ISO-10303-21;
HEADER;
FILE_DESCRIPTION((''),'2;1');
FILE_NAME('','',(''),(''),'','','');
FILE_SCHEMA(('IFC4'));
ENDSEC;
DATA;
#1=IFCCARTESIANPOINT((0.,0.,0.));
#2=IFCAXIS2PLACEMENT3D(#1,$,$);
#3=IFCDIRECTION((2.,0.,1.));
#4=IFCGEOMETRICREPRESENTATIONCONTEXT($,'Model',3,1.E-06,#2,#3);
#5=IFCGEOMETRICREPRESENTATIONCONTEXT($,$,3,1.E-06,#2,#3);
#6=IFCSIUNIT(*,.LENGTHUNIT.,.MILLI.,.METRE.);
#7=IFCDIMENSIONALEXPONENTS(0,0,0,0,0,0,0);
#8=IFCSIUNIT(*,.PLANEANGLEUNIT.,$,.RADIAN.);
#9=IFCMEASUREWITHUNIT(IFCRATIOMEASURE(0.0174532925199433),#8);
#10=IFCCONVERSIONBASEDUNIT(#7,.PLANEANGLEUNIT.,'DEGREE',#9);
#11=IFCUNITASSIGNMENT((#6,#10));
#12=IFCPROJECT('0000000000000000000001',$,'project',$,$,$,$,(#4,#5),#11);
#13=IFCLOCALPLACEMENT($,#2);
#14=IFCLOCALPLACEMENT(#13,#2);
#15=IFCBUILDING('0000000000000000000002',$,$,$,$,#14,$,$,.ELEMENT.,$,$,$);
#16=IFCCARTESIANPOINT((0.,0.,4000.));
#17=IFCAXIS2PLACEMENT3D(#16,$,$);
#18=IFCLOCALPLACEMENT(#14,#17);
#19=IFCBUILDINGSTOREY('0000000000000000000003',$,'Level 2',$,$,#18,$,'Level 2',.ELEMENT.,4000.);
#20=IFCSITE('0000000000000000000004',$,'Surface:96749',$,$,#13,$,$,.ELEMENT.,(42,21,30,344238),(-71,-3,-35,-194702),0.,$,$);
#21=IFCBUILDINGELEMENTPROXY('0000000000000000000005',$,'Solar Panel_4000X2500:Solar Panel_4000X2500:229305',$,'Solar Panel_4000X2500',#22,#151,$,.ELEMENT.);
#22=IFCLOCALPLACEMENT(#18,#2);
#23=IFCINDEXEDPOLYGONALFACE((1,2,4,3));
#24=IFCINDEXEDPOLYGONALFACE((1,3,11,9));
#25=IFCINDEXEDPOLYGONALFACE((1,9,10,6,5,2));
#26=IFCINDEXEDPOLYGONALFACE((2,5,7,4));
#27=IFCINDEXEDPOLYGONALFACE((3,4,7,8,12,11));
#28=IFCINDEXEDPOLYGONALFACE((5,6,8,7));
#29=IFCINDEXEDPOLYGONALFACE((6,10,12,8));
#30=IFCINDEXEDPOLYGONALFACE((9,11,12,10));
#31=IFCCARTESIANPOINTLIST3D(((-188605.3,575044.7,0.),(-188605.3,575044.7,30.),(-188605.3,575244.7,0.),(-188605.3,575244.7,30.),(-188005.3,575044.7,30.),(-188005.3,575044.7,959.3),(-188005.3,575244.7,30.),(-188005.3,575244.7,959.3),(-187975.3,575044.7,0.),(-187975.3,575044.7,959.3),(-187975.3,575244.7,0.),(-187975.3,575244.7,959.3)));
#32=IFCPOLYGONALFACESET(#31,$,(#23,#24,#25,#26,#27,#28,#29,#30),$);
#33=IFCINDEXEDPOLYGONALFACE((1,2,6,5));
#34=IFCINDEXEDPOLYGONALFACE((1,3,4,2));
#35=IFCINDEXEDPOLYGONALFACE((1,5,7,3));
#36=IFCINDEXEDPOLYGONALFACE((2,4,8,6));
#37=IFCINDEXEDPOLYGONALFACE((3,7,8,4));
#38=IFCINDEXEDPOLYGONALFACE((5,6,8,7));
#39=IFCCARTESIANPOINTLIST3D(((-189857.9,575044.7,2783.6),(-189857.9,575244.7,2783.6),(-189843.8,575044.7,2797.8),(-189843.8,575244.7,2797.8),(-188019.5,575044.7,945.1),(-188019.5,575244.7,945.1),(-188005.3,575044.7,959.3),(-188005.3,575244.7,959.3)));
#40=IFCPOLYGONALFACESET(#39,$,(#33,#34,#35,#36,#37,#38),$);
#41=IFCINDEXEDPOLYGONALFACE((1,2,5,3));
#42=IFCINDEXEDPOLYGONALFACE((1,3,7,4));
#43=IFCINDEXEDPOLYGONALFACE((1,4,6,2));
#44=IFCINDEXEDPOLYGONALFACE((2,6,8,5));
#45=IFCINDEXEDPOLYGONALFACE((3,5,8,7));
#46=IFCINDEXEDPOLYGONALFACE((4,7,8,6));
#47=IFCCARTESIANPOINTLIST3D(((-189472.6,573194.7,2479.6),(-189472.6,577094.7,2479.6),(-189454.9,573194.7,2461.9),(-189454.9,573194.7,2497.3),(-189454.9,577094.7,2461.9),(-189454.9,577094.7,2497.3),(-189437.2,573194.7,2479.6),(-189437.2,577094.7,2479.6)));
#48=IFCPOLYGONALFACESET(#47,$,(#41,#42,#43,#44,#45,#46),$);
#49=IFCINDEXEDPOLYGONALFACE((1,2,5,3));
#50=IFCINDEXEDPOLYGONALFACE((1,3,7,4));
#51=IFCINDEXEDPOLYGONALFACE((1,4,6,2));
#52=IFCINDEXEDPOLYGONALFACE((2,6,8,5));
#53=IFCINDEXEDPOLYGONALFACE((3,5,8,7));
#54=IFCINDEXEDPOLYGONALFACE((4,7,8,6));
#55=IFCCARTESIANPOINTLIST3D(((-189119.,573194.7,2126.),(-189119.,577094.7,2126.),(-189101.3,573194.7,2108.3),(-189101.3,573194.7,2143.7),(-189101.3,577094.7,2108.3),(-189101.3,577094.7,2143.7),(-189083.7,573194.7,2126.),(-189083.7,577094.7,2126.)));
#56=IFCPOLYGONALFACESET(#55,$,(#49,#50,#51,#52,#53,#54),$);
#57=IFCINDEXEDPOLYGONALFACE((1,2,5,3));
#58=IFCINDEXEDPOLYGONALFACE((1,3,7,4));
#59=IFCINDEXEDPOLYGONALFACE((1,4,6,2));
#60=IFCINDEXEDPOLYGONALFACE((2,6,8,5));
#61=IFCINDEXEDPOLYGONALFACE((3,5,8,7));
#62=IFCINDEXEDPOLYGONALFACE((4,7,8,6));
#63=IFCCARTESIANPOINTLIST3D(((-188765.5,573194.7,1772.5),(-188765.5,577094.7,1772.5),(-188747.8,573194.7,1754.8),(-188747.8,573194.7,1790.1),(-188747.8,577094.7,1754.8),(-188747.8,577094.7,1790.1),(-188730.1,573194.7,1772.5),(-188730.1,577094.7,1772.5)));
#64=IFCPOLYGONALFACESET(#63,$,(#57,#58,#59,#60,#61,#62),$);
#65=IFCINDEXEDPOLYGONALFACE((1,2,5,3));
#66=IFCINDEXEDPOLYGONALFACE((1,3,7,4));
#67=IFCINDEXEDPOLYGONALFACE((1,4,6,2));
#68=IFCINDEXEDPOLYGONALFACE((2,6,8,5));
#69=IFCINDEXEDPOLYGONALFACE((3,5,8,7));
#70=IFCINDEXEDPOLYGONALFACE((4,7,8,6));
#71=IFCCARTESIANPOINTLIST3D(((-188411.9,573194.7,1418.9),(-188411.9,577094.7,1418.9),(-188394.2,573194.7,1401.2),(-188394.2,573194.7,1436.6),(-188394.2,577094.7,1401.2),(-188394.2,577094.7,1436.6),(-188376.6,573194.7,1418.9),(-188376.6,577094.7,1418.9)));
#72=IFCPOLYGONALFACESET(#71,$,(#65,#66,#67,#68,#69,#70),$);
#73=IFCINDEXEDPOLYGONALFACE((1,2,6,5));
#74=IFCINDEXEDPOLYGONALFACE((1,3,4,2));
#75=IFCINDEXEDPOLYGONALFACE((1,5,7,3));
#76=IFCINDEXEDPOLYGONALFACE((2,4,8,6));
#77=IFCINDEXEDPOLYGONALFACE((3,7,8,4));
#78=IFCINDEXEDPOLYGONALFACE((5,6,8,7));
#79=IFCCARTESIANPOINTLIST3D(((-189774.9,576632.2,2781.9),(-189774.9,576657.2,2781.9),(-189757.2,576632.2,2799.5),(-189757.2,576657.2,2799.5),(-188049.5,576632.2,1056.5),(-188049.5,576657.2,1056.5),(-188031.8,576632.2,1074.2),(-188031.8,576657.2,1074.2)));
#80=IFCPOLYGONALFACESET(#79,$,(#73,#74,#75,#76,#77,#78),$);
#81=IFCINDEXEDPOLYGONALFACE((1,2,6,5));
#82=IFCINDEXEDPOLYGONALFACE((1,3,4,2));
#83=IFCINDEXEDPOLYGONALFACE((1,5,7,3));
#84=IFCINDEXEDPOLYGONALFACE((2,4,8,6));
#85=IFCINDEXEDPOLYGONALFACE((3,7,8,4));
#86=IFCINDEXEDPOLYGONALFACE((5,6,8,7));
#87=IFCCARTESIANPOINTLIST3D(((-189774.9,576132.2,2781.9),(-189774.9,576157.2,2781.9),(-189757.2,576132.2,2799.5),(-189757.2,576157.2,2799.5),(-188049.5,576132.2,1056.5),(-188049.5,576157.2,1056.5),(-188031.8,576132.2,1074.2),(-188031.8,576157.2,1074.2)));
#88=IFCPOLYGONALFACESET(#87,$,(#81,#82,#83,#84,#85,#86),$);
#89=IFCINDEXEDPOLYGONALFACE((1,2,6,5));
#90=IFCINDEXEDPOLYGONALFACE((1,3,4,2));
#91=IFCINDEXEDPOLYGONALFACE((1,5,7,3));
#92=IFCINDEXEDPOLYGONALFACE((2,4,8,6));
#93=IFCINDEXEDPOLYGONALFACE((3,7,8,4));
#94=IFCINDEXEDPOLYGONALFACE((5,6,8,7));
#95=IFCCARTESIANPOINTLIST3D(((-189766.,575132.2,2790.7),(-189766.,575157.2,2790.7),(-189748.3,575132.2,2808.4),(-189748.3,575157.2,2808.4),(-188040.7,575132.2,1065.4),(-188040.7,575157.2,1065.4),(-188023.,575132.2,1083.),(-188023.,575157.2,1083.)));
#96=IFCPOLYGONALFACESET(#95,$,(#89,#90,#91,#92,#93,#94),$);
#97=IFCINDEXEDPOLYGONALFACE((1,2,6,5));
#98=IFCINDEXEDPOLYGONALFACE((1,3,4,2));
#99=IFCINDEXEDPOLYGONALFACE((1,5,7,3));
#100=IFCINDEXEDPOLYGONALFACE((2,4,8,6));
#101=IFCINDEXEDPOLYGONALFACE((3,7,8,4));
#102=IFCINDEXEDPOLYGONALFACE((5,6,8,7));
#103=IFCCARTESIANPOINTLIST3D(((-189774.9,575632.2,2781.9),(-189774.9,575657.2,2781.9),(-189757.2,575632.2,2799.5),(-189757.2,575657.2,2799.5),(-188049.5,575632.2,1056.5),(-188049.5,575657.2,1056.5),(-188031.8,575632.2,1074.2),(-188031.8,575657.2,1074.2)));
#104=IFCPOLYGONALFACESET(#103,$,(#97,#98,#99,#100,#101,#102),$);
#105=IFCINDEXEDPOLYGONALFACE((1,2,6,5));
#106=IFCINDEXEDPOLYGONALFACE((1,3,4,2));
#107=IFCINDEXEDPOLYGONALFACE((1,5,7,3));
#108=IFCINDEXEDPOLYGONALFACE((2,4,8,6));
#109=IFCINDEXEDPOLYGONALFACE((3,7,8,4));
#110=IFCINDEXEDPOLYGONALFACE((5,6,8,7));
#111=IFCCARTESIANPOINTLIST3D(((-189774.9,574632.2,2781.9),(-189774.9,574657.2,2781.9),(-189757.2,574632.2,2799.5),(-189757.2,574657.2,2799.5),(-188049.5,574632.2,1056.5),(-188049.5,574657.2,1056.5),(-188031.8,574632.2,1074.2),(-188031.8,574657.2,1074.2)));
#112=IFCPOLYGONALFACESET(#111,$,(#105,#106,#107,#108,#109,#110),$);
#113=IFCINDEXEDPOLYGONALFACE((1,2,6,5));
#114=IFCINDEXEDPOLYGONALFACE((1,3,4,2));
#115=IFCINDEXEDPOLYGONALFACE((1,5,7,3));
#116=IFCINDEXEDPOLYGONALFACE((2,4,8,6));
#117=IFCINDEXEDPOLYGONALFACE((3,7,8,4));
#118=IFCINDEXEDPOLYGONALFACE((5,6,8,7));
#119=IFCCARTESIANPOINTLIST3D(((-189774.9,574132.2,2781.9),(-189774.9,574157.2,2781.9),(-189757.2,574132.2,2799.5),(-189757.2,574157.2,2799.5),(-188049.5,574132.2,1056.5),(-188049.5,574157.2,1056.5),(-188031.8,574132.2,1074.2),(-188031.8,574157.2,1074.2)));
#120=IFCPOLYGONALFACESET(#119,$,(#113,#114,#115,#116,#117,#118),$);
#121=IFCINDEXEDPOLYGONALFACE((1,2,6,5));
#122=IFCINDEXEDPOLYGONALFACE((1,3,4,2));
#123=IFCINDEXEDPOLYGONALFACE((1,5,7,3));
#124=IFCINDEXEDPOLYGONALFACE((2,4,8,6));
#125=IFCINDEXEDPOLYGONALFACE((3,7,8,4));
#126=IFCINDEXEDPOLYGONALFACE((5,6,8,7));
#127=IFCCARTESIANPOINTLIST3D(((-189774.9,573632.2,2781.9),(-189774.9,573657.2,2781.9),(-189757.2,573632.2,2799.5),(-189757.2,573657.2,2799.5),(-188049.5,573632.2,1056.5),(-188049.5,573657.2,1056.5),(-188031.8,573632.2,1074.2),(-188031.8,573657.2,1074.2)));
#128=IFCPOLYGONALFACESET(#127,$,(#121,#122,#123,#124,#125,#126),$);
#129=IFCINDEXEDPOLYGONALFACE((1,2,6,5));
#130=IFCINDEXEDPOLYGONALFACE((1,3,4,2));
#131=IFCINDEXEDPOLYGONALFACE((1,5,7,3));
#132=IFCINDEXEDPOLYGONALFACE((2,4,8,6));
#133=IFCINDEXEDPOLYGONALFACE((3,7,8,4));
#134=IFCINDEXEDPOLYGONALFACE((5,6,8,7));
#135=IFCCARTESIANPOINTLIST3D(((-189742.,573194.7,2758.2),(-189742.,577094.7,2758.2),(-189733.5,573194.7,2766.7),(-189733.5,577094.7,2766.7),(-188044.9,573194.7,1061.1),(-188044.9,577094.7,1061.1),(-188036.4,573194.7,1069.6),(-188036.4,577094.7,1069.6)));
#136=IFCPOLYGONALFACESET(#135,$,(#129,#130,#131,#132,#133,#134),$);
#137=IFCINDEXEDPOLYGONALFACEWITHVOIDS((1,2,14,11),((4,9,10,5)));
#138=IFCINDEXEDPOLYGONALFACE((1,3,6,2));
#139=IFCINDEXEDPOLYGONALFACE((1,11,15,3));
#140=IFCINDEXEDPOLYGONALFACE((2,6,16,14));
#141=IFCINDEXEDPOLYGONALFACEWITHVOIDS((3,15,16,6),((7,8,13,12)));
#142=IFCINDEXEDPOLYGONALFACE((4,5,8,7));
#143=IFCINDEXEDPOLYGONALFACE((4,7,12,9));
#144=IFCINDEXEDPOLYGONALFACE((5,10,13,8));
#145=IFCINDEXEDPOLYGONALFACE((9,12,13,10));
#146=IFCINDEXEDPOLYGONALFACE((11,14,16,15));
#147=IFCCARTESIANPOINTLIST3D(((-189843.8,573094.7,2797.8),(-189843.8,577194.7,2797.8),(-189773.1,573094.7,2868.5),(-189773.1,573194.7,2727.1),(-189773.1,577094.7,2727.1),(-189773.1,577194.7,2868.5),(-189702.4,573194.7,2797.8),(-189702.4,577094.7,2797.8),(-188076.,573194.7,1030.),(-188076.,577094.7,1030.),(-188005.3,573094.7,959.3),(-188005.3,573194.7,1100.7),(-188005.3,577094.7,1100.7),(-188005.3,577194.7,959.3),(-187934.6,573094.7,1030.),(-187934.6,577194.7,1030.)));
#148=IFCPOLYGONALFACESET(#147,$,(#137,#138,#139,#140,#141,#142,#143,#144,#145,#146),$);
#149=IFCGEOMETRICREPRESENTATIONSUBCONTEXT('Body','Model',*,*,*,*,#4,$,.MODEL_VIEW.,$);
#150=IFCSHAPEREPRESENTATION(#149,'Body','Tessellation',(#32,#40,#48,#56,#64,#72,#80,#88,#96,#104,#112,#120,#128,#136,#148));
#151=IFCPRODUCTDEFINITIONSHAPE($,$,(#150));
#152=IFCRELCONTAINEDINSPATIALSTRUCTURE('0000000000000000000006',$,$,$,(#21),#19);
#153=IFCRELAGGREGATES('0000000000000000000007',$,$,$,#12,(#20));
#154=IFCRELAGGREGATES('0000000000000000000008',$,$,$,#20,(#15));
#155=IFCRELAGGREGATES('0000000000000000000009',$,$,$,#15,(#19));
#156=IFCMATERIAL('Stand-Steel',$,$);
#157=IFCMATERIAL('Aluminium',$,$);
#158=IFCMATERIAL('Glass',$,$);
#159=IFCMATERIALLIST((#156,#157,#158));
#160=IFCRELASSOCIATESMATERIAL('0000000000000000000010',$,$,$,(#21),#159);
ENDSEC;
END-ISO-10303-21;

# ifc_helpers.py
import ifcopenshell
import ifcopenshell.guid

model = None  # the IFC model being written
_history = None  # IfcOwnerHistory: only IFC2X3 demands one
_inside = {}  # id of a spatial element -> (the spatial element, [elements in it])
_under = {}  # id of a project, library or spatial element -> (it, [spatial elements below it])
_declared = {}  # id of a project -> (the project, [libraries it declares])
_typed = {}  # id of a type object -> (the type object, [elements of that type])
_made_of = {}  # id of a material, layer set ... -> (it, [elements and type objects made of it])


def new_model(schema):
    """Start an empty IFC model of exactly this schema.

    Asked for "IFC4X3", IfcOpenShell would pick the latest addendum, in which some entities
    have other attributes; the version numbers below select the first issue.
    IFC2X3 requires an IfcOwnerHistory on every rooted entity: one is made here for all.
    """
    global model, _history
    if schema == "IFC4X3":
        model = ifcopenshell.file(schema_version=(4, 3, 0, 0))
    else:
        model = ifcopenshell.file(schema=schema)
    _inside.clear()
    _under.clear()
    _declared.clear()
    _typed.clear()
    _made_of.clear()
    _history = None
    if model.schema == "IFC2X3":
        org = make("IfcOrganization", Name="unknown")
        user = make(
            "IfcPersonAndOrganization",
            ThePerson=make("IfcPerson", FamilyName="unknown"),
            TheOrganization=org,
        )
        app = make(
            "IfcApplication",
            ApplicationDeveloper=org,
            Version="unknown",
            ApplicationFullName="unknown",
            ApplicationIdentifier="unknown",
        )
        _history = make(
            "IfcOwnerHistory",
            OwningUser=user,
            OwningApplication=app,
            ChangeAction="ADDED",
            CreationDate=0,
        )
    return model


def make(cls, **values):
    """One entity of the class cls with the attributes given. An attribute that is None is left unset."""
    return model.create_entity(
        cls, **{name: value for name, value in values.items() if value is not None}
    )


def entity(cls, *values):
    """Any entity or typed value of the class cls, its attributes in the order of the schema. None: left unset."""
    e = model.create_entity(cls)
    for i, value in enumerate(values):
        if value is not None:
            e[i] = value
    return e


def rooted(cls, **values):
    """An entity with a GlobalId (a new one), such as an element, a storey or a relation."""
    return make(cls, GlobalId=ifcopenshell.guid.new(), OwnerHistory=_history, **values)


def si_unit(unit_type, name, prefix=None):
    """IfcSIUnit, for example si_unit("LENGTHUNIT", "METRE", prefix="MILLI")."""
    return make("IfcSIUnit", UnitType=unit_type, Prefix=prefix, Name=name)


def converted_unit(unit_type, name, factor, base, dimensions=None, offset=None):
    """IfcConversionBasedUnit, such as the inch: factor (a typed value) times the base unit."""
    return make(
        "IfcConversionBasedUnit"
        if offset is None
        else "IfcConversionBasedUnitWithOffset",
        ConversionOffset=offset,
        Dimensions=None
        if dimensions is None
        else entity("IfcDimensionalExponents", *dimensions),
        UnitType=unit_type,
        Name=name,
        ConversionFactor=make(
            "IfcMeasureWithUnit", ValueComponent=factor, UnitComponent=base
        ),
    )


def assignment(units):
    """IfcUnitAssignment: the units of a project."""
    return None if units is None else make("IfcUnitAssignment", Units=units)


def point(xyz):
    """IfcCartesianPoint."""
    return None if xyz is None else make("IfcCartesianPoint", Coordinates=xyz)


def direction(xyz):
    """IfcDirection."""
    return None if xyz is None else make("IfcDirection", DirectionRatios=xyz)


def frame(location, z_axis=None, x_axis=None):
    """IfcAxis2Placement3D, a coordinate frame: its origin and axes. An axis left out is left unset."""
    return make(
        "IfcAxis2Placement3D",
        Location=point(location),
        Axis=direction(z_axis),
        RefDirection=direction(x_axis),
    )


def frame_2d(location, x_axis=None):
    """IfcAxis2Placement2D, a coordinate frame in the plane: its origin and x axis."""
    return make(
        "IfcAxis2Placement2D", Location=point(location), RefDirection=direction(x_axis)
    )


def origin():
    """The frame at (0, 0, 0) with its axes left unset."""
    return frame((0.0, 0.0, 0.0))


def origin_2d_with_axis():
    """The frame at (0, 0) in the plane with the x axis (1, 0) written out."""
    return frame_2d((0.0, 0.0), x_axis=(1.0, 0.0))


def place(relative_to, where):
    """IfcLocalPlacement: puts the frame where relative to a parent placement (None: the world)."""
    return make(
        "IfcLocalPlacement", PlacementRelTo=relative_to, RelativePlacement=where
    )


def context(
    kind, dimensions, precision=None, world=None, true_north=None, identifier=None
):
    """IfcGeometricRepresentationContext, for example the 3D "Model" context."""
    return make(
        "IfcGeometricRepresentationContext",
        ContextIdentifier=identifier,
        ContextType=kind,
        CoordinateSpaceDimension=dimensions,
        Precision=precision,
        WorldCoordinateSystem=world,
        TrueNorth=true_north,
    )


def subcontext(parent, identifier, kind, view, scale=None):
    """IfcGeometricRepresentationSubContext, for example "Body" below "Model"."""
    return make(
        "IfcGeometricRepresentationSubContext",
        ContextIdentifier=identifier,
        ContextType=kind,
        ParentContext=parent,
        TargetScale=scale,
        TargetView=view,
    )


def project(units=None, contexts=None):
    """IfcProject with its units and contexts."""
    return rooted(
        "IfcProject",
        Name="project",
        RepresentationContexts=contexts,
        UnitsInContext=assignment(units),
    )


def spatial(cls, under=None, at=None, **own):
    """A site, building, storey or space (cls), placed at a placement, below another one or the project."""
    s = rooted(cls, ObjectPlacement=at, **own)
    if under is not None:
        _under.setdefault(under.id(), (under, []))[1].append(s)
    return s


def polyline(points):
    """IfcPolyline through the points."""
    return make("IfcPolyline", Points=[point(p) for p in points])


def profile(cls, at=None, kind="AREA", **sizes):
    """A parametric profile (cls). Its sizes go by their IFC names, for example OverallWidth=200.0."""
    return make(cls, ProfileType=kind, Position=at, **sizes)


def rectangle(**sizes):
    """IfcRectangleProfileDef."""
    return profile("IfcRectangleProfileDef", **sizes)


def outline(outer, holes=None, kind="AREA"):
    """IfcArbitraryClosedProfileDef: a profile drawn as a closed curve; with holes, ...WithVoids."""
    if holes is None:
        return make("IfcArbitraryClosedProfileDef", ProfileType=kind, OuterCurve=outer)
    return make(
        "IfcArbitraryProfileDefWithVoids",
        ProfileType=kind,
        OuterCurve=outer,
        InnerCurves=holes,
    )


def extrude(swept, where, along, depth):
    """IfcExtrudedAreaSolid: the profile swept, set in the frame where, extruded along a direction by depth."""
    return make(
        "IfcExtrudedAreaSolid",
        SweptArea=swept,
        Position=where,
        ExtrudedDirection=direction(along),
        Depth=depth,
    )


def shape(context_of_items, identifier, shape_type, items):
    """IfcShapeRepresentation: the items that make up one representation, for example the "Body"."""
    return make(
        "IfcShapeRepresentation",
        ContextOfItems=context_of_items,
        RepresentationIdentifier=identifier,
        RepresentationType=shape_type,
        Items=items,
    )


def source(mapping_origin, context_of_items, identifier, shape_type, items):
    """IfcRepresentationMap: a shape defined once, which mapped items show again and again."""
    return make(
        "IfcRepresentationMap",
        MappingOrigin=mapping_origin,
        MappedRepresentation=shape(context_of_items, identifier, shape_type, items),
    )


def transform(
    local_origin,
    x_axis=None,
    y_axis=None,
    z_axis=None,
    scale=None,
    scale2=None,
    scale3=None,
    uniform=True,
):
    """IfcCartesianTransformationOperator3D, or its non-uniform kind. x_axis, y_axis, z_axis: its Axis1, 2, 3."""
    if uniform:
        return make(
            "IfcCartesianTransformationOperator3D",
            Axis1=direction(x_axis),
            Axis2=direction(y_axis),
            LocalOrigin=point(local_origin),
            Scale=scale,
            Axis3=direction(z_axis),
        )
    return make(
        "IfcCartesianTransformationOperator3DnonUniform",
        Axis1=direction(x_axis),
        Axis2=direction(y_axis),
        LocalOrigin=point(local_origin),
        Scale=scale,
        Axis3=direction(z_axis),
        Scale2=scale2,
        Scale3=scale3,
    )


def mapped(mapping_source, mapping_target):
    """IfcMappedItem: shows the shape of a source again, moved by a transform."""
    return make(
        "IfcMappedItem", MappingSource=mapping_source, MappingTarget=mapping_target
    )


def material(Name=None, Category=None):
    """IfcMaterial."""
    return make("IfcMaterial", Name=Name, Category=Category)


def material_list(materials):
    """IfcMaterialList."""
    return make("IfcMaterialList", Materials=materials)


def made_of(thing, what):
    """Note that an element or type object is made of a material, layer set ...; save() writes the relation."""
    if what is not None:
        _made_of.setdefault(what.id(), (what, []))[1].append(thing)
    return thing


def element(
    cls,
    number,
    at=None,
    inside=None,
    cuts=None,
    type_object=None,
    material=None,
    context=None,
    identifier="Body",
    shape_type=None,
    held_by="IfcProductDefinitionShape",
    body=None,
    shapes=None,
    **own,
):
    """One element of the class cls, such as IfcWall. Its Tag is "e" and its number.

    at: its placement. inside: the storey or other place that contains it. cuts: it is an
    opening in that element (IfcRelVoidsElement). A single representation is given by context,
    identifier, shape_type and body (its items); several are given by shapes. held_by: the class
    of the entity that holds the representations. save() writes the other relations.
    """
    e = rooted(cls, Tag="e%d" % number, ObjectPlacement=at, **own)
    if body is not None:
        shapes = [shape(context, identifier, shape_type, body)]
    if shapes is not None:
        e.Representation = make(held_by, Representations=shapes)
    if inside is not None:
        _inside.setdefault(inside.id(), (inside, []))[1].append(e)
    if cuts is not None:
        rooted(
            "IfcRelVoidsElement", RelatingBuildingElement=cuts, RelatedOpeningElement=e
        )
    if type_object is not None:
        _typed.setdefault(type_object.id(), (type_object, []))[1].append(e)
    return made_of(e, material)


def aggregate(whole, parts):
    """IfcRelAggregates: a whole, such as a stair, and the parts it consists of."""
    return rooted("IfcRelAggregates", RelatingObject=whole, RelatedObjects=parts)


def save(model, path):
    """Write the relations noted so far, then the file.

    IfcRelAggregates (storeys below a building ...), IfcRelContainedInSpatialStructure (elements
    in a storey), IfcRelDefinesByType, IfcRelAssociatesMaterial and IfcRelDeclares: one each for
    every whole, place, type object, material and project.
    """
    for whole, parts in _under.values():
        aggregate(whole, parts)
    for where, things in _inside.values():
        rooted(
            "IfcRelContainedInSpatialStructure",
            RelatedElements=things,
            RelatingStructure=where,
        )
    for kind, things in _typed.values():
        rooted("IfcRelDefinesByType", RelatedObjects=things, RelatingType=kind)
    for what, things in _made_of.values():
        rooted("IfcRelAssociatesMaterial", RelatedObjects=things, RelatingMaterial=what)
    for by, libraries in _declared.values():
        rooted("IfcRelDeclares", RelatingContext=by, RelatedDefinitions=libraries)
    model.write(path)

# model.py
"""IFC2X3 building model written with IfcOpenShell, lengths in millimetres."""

from ifc_helpers import new_model, entity, si_unit, converted_unit, direction, frame, frame_2d, origin, origin_2d_with_axis, place, context, subcontext, project, spatial, polyline, rectangle, outline, extrude, source, transform, mapped, material, material_list, element, save


model = new_model("IFC2X3")

# Units and contexts
model_context = context("Model", 3, precision=1e-06, world=origin(), true_north=direction((2.0, 0.0, 1.0)))
context_of_model = context(None, 3, precision=1e-06, world=origin(), true_north=direction((2.0, 0.0, 1.0)))
body_context = subcontext(model_context, "Body", "Model", "MODEL_VIEW")
ifc_project = project(units=[si_unit("LENGTHUNIT", "METRE", prefix="MILLI"), converted_unit("PLANEANGLEUNIT", "DEGREE", entity("IfcRatioMeasure", 0.0174532925199433), si_unit("PLANEANGLEUNIT", "RADIAN"), dimensions=[0, 0, 0, 0, 0, 0, 0])], contexts=[model_context, context_of_model])

# Site, building, storey
site_placement = place(None, origin())
site = spatial("IfcSite", under=ifc_project, at=site_placement, Name="Surface:96749", CompositionType="ELEMENT", RefLatitude=(42, 21, 30, 344238), RefLongitude=(-71, -3, -35, -194702), RefElevation=0.0)
building_placement = place(site_placement, origin())
building = spatial("IfcBuilding", under=site, at=building_placement, CompositionType="ELEMENT")
storey_placement = place(building_placement, frame((0.0, 0.0, 4000.0)))
storey = spatial("IfcBuildingStorey", under=building, at=storey_placement, Name="Level 2", LongName="Level 2", CompositionType="ELEMENT", Elevation=4000.0)

# Building element proxy
ifc_material_1 = material(Name="Stand-Steel")
ifc_material_2 = material(Name="Aluminium")
ifc_material_3 = material(Name="Glass")
shared_shape = source(origin(), body_context, "Body", "SweptSolid", [
    extrude(outline(polyline([(-629.5, -220.0), (329.8, -220.0), (329.8, 410.0), (299.8, 410.0), (299.8, -190.0), (-629.5, -190.0), (-629.5, -220.0)])), frame((-190.0, -100.0, 299.8), z_axis=(0.0, 1.0, 0.0), x_axis=(0.0, 0.0, -1.0)), (0.0, 0.0, 1.0), 200.0),
    extrude(rectangle(XDim=20.0, YDim=200.0, at=frame_2d((0.0, 0.0), x_axis=(0.0, 1.0))), frame((-7.1, 0.0, 922.2), z_axis=(-0.707107, 0.0, 0.707107), x_axis=(0.0, 1.0, 0.0)), (0.0, 0.0, 1.0), 2600.0),
    extrude(rectangle(XDim=25.0, YDim=25.0, at=frame_2d((0.0, 0.0), x_axis=(1.0, 0.0))), frame((-1449.6, -1950.0, 2449.6), z_axis=(0.0, 1.0, 0.0), x_axis=(-0.707107, 0.0, -0.707107)), (0.0, 0.0, 1.0), 3900.0),
    extrude(rectangle(XDim=25.0, YDim=25.0, at=origin_2d_with_axis()), frame((-1096.0, -1950.0, 2096.0), z_axis=(0.0, 1.0, 0.0), x_axis=(-0.707107, 0.0, -0.707107)), (0.0, 0.0, 1.0), 3900.0),
    extrude(rectangle(XDim=25.0, YDim=25.0, at=origin_2d_with_axis()), frame((-742.5, -1950.0, 1742.5), z_axis=(0.0, 1.0, 0.0), x_axis=(-0.707107, 0.0, -0.707107)), (0.0, 0.0, 1.0), 3900.0),
    extrude(rectangle(XDim=25.0, YDim=25.0, at=frame_2d((0.0, 0.0), x_axis=(1.0, 0.0))), frame((-388.9, -1950.0, 1388.9), z_axis=(0.0, 1.0, 0.0), x_axis=(-0.707107, 0.0, -0.707107)), (0.0, 0.0, 1.0), 3900.0),
    extrude(rectangle(XDim=25.0, YDim=25.0, at=frame_2d((0.0, 0.0), x_axis=(0.0, 1.0))), frame((-35.4, 1500.0, 1035.4), z_axis=(-0.707107, 0.0, 0.707107), x_axis=(0.0, 1.0, 0.0)), (0.0, 0.0, 1.0), 2440.0),
    extrude(rectangle(XDim=25.0, YDim=25.0, at=frame_2d((0.0, 0.0), x_axis=(0.0, 1.0))), frame((-35.4, 1000.0, 1035.4), z_axis=(-0.707107, 0.0, 0.707107), x_axis=(0.0, 1.0, 0.0)), (0.0, 0.0, 1.0), 2440.0),
    extrude(rectangle(XDim=25.0, YDim=25.0, at=frame_2d((0.0, 0.0), x_axis=(0.0, 1.0))), frame((-26.5, 0.0, 1044.2), z_axis=(-0.707107, 0.0, 0.707107), x_axis=(0.0, -1.0, 0.0)), (0.0, 0.0, 1.0), 2440.0),
    extrude(rectangle(XDim=25.0, YDim=25.0, at=frame_2d((0.0, 0.0), x_axis=(0.0, 1.0))), frame((-35.4, 500.0, 1035.4), z_axis=(-0.707107, 0.0, 0.707107), x_axis=(0.0, 1.0, 0.0)), (0.0, 0.0, 1.0), 2440.0),
    extrude(rectangle(XDim=25.0, YDim=25.0, at=frame_2d((0.0, 0.0), x_axis=(0.0, 1.0))), frame((-35.4, -500.0, 1035.4), z_axis=(-0.707107, 0.0, 0.707107), x_axis=(0.0, 1.0, 0.0)), (0.0, 0.0, 1.0), 2440.0),
    extrude(rectangle(XDim=25.0, YDim=25.0, at=frame_2d((0.0, 0.0), x_axis=(0.0, 1.0))), frame((-35.4, -1000.0, 1035.4), z_axis=(-0.707107, 0.0, 0.707107), x_axis=(0.0, 1.0, 0.0)), (0.0, 0.0, 1.0), 2440.0),
    extrude(rectangle(XDim=25.0, YDim=25.0, at=frame_2d((0.0, 0.0), x_axis=(0.0, 1.0))), frame((-35.4, -1500.0, 1035.4), z_axis=(-0.707107, 0.0, 0.707107), x_axis=(0.0, 1.0, 0.0)), (0.0, 0.0, 1.0), 2440.0),
    extrude(rectangle(XDim=2400.0, YDim=12.0, at=frame_2d((0.0, 0.0), x_axis=(1.0, 0.0))), frame((-883.9, -1950.0, 1883.9), z_axis=(0.0, 1.0, 0.0), x_axis=(0.707107, 0.0, -0.707107)), (0.0, 0.0, 1.0), 3900.0),
    extrude(outline(polyline([(-2050.0, -1300.0), (2050.0, -1300.0), (2050.0, 1300.0), (-2050.0, 1300.0), (-2050.0, -1300.0)]), holes=[polyline([(1950.0, -1200.0), (-1950.0, -1200.0), (-1950.0, 1200.0), (1950.0, 1200.0), (1950.0, -1200.0)])]), frame((-919.2, 0.0, 1848.5), z_axis=(0.707107, 0.0, 0.707107), x_axis=(0.0, 1.0, 0.0)), (0.0, 0.0, 1.0), 100.0),
])
ifc_material_list_1 = material_list([ifc_material_1, ifc_material_2, ifc_material_3])
proxy_1_placement = place(storey_placement, frame((-188005.3, 575144.7, 30.0)))
element("IfcBuildingElementProxy", 1, at=proxy_1_placement, inside=storey, material=ifc_material_list_1, Name="Solar Panel_4000X2500:Solar Panel_4000X2500:229305", ObjectType="Solar Panel_4000X2500", CompositionType="ELEMENT", context=body_context, shape_type="MappedRepresentation", body=[
    mapped(shared_shape, transform((0.0, 0.0, 0.0), scale=1.0)),
])

save(model, "model.ifc")
